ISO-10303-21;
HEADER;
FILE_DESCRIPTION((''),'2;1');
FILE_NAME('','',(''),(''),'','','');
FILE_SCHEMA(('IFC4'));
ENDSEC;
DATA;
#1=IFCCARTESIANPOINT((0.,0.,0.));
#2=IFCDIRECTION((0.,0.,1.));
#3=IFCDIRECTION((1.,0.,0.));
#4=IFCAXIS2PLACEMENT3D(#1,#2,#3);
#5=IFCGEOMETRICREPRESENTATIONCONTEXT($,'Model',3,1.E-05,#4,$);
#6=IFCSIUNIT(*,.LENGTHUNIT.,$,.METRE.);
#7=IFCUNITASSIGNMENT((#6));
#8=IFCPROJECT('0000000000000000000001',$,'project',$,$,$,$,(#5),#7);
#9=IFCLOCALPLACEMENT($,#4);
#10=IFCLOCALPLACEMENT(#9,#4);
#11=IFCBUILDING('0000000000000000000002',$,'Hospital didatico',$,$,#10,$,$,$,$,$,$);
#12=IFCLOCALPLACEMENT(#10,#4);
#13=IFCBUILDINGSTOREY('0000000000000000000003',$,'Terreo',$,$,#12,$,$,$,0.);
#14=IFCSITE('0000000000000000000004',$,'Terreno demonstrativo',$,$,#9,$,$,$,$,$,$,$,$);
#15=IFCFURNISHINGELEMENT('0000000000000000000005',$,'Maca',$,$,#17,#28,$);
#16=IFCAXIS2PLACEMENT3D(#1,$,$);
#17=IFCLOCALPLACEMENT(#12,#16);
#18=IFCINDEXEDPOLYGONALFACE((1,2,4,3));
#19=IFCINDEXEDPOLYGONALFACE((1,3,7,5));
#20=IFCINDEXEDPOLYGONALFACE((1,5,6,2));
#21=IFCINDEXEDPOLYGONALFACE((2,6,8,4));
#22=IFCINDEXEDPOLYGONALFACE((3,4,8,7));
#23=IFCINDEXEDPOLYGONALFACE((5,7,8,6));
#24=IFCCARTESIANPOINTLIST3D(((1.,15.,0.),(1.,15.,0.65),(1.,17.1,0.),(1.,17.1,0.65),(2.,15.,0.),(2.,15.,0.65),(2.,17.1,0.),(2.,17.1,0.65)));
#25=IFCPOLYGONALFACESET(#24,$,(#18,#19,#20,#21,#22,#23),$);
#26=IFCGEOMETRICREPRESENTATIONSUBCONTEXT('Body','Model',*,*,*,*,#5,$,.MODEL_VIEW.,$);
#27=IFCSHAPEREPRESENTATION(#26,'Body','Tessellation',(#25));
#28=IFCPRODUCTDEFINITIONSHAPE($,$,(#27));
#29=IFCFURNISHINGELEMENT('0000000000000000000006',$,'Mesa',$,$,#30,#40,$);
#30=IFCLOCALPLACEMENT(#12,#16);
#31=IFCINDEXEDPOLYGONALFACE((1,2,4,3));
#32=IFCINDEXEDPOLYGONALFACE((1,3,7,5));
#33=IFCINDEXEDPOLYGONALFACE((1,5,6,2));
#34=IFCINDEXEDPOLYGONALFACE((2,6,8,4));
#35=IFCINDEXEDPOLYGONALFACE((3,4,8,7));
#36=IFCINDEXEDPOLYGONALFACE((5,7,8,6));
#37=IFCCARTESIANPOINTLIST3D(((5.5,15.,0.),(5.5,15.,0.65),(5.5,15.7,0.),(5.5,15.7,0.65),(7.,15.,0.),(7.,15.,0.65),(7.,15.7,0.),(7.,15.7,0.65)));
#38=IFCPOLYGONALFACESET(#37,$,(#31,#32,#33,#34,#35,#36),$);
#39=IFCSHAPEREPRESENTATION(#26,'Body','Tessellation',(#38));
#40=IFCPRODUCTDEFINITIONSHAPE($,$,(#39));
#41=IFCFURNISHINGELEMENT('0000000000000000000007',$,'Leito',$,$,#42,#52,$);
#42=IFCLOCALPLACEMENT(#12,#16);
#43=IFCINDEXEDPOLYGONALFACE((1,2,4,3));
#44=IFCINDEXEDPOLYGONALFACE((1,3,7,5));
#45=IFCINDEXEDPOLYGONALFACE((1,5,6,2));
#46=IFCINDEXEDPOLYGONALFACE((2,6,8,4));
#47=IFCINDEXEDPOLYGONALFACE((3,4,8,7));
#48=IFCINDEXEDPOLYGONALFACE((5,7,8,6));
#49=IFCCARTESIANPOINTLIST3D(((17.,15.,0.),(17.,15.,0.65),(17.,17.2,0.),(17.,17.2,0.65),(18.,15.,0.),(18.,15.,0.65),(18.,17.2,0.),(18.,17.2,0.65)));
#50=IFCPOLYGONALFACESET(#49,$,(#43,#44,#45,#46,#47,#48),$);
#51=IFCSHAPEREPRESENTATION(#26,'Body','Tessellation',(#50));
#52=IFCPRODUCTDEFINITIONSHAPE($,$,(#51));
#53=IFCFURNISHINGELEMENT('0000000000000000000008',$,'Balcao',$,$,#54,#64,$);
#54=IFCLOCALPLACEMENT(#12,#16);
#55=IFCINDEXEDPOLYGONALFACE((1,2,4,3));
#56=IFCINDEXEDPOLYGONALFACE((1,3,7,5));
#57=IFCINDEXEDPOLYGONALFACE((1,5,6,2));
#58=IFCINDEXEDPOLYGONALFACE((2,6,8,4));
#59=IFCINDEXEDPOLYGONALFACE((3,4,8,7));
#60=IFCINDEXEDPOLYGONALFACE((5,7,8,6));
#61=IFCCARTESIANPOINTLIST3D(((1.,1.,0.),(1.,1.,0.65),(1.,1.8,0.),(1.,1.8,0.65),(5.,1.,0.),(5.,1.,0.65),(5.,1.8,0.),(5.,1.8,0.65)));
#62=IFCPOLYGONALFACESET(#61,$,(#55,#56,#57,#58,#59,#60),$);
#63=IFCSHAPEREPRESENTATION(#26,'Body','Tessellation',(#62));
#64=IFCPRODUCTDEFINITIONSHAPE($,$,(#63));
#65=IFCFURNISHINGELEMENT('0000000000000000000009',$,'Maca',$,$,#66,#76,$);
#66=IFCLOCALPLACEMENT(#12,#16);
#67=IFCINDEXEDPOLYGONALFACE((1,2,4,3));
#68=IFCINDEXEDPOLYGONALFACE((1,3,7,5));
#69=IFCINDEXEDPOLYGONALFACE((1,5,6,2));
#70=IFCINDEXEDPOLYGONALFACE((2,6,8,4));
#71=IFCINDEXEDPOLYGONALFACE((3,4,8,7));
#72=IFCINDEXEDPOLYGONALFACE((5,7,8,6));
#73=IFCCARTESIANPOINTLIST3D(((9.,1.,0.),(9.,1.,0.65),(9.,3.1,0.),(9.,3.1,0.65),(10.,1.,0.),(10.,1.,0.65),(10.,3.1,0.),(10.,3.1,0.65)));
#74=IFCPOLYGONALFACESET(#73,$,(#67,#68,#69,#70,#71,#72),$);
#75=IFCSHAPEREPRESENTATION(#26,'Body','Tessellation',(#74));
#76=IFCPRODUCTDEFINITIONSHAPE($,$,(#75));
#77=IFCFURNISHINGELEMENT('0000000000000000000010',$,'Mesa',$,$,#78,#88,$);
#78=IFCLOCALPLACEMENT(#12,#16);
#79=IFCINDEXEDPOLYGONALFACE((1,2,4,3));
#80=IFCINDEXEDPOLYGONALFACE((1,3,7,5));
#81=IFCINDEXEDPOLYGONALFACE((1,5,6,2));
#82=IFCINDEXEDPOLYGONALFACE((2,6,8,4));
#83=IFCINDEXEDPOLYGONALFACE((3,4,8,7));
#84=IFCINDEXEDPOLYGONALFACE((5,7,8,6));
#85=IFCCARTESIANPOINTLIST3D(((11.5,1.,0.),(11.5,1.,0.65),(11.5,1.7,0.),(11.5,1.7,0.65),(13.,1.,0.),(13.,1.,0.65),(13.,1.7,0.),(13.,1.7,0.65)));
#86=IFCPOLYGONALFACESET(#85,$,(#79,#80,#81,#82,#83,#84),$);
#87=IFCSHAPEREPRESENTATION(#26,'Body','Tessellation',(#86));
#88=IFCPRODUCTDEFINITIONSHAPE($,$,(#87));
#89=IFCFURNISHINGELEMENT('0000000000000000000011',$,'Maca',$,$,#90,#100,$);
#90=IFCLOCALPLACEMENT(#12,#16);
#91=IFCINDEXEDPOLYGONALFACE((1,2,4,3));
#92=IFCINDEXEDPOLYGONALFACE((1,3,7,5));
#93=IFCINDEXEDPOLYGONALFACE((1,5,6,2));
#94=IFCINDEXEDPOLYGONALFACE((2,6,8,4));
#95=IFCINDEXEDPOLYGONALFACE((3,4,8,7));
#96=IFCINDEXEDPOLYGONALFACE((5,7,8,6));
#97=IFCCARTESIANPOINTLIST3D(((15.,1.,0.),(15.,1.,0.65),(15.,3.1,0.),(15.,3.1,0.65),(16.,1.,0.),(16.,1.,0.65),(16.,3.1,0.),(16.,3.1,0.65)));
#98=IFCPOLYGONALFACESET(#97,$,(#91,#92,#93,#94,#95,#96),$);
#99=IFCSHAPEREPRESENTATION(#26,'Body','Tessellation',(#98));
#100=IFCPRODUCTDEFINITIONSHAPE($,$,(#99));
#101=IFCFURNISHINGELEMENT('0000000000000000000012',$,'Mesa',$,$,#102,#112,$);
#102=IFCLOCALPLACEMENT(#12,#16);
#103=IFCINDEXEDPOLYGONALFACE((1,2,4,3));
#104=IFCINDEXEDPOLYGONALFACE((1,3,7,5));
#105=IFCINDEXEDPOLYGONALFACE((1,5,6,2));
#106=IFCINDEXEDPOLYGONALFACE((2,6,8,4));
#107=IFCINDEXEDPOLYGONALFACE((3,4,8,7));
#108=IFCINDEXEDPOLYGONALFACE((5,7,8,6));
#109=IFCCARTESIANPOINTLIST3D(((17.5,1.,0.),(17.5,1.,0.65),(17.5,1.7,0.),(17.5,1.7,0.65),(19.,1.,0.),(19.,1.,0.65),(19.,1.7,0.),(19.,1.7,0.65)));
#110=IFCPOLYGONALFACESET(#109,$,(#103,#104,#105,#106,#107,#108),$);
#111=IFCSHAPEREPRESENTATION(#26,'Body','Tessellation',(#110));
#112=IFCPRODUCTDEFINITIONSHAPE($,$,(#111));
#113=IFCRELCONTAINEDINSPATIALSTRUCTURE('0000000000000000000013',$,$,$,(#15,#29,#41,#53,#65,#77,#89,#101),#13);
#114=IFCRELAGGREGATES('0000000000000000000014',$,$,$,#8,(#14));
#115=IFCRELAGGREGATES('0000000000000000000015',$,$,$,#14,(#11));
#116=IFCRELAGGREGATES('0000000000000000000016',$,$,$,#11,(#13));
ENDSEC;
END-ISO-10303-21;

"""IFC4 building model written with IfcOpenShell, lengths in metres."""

from ifc_helpers import new_model, si_unit, frame, origin_with_axes, place, context, subcontext, project, spatial, indexed_curve, outline, extrude, element, save


model = new_model("IFC4")

# Units and contexts
model_context = context("Model", 3, precision=1e-05, world=origin_with_axes())
body_context = subcontext(model_context, "Body", "Model", "MODEL_VIEW")
ifc_project = project(units=[si_unit("LENGTHUNIT", "METRE")], contexts=[model_context])

# Site, building, storey
site_placement = place(None, origin_with_axes())
site = spatial("IfcSite", under=ifc_project, at=site_placement, Name="Terreno demonstrativo")
building_placement = place(site_placement, origin_with_axes())
building = spatial("IfcBuilding", under=site, at=building_placement, Name="Hospital didatico")
storey_placement = place(building_placement, origin_with_axes())
storey = spatial("IfcBuildingStorey", under=building, at=storey_placement, Name="Terreo", Elevation=0.0)

# Furnishing elements
furnishing_1_placement = place(storey_placement, frame((1.0, 15.0, 0.0), z_axis=(0.0, 0.0, 1.0), x_axis=(1.0, 0.0, 0.0)))
element("IfcFurnishingElement", 1, at=furnishing_1_placement, inside=storey, Name="Maca", context=body_context, shape_type="SweptSolid", body=[
    extrude(outline(indexed_curve([(0.0, 0.0), (0.0, 2.1), (1.0, 2.1), (1.0, 0.0), (0.0, 0.0)], self_intersect=False)), origin_with_axes(), (0.0, 0.0, 1.0), 0.65),
])
furnishing_2_placement = place(storey_placement, frame((5.5, 15.0, 0.0), z_axis=(0.0, 0.0, 1.0), x_axis=(1.0, 0.0, 0.0)))
element("IfcFurnishingElement", 2, at=furnishing_2_placement, inside=storey, Name="Mesa", context=body_context, shape_type="SweptSolid", body=[
    extrude(outline(indexed_curve([(0.0, 0.0), (0.0, 0.7), (1.5, 0.7), (1.5, 0.0), (0.0, 0.0)], self_intersect=False)), origin_with_axes(), (0.0, 0.0, 1.0), 0.65),
])
furnishing_3_placement = place(storey_placement, frame((17.0, 15.0, 0.0), z_axis=(0.0, 0.0, 1.0), x_axis=(1.0, 0.0, 0.0)))
element("IfcFurnishingElement", 3, at=furnishing_3_placement, inside=storey, Name="Leito", context=body_context, shape_type="SweptSolid", body=[
    extrude(outline(indexed_curve([(0.0, 0.0), (0.0, 2.2), (1.0, 2.2), (1.0, 0.0), (0.0, 0.0)], self_intersect=False)), origin_with_axes(), (0.0, 0.0, 1.0), 0.65),
])
furnishing_4_placement = place(storey_placement, frame((1.0, 1.0, 0.0), z_axis=(0.0, 0.0, 1.0), x_axis=(1.0, 0.0, 0.0)))
element("IfcFurnishingElement", 4, at=furnishing_4_placement, inside=storey, Name="Balcao", context=body_context, shape_type="SweptSolid", body=[
    extrude(outline(indexed_curve([(0.0, 0.0), (0.0, 0.8), (4.0, 0.8), (4.0, 0.0), (0.0, 0.0)], self_intersect=False)), origin_with_axes(), (0.0, 0.0, 1.0), 0.65),
])
furnishing_5_placement = place(storey_placement, frame((9.0, 1.0, 0.0), z_axis=(0.0, 0.0, 1.0), x_axis=(1.0, 0.0, 0.0)))
element("IfcFurnishingElement", 5, at=furnishing_5_placement, inside=storey, Name="Maca", context=body_context, shape_type="SweptSolid", body=[
    extrude(outline(indexed_curve([(0.0, 0.0), (0.0, 2.1), (1.0, 2.1), (1.0, 0.0), (0.0, 0.0)], self_intersect=False)), origin_with_axes(), (0.0, 0.0, 1.0), 0.65),
])
furnishing_6_placement = place(storey_placement, frame((11.5, 1.0, 0.0), z_axis=(0.0, 0.0, 1.0), x_axis=(1.0, 0.0, 0.0)))
element("IfcFurnishingElement", 6, at=furnishing_6_placement, inside=storey, Name="Mesa", context=body_context, shape_type="SweptSolid", body=[
    extrude(outline(indexed_curve([(0.0, 0.0), (0.0, 0.7), (1.5, 0.7), (1.5, 0.0), (0.0, 0.0)], self_intersect=False)), origin_with_axes(), (0.0, 0.0, 1.0), 0.65),
])
furnishing_7_placement = place(storey_placement, frame((15.0, 1.0, 0.0), z_axis=(0.0, 0.0, 1.0), x_axis=(1.0, 0.0, 0.0)))
element("IfcFurnishingElement", 7, at=furnishing_7_placement, inside=storey, Name="Maca", context=body_context, shape_type="SweptSolid", body=[
    extrude(outline(indexed_curve([(0.0, 0.0), (0.0, 2.1), (1.0, 2.1), (1.0, 0.0), (0.0, 0.0)], self_intersect=False)), origin_with_axes(), (0.0, 0.0, 1.0), 0.65),
])
furnishing_8_placement = place(storey_placement, frame((17.5, 1.0, 0.0), z_axis=(0.0, 0.0, 1.0), x_axis=(1.0, 0.0, 0.0)))
element("IfcFurnishingElement", 8, at=furnishing_8_placement, inside=storey, Name="Mesa", context=body_context, shape_type="SweptSolid", body=[
    extrude(outline(indexed_curve([(0.0, 0.0), (0.0, 0.7), (1.5, 0.7), (1.5, 0.0), (0.0, 0.0)], self_intersect=False)), origin_with_axes(), (0.0, 0.0, 1.0), 0.65),
])

save(model, "model.ifc")
